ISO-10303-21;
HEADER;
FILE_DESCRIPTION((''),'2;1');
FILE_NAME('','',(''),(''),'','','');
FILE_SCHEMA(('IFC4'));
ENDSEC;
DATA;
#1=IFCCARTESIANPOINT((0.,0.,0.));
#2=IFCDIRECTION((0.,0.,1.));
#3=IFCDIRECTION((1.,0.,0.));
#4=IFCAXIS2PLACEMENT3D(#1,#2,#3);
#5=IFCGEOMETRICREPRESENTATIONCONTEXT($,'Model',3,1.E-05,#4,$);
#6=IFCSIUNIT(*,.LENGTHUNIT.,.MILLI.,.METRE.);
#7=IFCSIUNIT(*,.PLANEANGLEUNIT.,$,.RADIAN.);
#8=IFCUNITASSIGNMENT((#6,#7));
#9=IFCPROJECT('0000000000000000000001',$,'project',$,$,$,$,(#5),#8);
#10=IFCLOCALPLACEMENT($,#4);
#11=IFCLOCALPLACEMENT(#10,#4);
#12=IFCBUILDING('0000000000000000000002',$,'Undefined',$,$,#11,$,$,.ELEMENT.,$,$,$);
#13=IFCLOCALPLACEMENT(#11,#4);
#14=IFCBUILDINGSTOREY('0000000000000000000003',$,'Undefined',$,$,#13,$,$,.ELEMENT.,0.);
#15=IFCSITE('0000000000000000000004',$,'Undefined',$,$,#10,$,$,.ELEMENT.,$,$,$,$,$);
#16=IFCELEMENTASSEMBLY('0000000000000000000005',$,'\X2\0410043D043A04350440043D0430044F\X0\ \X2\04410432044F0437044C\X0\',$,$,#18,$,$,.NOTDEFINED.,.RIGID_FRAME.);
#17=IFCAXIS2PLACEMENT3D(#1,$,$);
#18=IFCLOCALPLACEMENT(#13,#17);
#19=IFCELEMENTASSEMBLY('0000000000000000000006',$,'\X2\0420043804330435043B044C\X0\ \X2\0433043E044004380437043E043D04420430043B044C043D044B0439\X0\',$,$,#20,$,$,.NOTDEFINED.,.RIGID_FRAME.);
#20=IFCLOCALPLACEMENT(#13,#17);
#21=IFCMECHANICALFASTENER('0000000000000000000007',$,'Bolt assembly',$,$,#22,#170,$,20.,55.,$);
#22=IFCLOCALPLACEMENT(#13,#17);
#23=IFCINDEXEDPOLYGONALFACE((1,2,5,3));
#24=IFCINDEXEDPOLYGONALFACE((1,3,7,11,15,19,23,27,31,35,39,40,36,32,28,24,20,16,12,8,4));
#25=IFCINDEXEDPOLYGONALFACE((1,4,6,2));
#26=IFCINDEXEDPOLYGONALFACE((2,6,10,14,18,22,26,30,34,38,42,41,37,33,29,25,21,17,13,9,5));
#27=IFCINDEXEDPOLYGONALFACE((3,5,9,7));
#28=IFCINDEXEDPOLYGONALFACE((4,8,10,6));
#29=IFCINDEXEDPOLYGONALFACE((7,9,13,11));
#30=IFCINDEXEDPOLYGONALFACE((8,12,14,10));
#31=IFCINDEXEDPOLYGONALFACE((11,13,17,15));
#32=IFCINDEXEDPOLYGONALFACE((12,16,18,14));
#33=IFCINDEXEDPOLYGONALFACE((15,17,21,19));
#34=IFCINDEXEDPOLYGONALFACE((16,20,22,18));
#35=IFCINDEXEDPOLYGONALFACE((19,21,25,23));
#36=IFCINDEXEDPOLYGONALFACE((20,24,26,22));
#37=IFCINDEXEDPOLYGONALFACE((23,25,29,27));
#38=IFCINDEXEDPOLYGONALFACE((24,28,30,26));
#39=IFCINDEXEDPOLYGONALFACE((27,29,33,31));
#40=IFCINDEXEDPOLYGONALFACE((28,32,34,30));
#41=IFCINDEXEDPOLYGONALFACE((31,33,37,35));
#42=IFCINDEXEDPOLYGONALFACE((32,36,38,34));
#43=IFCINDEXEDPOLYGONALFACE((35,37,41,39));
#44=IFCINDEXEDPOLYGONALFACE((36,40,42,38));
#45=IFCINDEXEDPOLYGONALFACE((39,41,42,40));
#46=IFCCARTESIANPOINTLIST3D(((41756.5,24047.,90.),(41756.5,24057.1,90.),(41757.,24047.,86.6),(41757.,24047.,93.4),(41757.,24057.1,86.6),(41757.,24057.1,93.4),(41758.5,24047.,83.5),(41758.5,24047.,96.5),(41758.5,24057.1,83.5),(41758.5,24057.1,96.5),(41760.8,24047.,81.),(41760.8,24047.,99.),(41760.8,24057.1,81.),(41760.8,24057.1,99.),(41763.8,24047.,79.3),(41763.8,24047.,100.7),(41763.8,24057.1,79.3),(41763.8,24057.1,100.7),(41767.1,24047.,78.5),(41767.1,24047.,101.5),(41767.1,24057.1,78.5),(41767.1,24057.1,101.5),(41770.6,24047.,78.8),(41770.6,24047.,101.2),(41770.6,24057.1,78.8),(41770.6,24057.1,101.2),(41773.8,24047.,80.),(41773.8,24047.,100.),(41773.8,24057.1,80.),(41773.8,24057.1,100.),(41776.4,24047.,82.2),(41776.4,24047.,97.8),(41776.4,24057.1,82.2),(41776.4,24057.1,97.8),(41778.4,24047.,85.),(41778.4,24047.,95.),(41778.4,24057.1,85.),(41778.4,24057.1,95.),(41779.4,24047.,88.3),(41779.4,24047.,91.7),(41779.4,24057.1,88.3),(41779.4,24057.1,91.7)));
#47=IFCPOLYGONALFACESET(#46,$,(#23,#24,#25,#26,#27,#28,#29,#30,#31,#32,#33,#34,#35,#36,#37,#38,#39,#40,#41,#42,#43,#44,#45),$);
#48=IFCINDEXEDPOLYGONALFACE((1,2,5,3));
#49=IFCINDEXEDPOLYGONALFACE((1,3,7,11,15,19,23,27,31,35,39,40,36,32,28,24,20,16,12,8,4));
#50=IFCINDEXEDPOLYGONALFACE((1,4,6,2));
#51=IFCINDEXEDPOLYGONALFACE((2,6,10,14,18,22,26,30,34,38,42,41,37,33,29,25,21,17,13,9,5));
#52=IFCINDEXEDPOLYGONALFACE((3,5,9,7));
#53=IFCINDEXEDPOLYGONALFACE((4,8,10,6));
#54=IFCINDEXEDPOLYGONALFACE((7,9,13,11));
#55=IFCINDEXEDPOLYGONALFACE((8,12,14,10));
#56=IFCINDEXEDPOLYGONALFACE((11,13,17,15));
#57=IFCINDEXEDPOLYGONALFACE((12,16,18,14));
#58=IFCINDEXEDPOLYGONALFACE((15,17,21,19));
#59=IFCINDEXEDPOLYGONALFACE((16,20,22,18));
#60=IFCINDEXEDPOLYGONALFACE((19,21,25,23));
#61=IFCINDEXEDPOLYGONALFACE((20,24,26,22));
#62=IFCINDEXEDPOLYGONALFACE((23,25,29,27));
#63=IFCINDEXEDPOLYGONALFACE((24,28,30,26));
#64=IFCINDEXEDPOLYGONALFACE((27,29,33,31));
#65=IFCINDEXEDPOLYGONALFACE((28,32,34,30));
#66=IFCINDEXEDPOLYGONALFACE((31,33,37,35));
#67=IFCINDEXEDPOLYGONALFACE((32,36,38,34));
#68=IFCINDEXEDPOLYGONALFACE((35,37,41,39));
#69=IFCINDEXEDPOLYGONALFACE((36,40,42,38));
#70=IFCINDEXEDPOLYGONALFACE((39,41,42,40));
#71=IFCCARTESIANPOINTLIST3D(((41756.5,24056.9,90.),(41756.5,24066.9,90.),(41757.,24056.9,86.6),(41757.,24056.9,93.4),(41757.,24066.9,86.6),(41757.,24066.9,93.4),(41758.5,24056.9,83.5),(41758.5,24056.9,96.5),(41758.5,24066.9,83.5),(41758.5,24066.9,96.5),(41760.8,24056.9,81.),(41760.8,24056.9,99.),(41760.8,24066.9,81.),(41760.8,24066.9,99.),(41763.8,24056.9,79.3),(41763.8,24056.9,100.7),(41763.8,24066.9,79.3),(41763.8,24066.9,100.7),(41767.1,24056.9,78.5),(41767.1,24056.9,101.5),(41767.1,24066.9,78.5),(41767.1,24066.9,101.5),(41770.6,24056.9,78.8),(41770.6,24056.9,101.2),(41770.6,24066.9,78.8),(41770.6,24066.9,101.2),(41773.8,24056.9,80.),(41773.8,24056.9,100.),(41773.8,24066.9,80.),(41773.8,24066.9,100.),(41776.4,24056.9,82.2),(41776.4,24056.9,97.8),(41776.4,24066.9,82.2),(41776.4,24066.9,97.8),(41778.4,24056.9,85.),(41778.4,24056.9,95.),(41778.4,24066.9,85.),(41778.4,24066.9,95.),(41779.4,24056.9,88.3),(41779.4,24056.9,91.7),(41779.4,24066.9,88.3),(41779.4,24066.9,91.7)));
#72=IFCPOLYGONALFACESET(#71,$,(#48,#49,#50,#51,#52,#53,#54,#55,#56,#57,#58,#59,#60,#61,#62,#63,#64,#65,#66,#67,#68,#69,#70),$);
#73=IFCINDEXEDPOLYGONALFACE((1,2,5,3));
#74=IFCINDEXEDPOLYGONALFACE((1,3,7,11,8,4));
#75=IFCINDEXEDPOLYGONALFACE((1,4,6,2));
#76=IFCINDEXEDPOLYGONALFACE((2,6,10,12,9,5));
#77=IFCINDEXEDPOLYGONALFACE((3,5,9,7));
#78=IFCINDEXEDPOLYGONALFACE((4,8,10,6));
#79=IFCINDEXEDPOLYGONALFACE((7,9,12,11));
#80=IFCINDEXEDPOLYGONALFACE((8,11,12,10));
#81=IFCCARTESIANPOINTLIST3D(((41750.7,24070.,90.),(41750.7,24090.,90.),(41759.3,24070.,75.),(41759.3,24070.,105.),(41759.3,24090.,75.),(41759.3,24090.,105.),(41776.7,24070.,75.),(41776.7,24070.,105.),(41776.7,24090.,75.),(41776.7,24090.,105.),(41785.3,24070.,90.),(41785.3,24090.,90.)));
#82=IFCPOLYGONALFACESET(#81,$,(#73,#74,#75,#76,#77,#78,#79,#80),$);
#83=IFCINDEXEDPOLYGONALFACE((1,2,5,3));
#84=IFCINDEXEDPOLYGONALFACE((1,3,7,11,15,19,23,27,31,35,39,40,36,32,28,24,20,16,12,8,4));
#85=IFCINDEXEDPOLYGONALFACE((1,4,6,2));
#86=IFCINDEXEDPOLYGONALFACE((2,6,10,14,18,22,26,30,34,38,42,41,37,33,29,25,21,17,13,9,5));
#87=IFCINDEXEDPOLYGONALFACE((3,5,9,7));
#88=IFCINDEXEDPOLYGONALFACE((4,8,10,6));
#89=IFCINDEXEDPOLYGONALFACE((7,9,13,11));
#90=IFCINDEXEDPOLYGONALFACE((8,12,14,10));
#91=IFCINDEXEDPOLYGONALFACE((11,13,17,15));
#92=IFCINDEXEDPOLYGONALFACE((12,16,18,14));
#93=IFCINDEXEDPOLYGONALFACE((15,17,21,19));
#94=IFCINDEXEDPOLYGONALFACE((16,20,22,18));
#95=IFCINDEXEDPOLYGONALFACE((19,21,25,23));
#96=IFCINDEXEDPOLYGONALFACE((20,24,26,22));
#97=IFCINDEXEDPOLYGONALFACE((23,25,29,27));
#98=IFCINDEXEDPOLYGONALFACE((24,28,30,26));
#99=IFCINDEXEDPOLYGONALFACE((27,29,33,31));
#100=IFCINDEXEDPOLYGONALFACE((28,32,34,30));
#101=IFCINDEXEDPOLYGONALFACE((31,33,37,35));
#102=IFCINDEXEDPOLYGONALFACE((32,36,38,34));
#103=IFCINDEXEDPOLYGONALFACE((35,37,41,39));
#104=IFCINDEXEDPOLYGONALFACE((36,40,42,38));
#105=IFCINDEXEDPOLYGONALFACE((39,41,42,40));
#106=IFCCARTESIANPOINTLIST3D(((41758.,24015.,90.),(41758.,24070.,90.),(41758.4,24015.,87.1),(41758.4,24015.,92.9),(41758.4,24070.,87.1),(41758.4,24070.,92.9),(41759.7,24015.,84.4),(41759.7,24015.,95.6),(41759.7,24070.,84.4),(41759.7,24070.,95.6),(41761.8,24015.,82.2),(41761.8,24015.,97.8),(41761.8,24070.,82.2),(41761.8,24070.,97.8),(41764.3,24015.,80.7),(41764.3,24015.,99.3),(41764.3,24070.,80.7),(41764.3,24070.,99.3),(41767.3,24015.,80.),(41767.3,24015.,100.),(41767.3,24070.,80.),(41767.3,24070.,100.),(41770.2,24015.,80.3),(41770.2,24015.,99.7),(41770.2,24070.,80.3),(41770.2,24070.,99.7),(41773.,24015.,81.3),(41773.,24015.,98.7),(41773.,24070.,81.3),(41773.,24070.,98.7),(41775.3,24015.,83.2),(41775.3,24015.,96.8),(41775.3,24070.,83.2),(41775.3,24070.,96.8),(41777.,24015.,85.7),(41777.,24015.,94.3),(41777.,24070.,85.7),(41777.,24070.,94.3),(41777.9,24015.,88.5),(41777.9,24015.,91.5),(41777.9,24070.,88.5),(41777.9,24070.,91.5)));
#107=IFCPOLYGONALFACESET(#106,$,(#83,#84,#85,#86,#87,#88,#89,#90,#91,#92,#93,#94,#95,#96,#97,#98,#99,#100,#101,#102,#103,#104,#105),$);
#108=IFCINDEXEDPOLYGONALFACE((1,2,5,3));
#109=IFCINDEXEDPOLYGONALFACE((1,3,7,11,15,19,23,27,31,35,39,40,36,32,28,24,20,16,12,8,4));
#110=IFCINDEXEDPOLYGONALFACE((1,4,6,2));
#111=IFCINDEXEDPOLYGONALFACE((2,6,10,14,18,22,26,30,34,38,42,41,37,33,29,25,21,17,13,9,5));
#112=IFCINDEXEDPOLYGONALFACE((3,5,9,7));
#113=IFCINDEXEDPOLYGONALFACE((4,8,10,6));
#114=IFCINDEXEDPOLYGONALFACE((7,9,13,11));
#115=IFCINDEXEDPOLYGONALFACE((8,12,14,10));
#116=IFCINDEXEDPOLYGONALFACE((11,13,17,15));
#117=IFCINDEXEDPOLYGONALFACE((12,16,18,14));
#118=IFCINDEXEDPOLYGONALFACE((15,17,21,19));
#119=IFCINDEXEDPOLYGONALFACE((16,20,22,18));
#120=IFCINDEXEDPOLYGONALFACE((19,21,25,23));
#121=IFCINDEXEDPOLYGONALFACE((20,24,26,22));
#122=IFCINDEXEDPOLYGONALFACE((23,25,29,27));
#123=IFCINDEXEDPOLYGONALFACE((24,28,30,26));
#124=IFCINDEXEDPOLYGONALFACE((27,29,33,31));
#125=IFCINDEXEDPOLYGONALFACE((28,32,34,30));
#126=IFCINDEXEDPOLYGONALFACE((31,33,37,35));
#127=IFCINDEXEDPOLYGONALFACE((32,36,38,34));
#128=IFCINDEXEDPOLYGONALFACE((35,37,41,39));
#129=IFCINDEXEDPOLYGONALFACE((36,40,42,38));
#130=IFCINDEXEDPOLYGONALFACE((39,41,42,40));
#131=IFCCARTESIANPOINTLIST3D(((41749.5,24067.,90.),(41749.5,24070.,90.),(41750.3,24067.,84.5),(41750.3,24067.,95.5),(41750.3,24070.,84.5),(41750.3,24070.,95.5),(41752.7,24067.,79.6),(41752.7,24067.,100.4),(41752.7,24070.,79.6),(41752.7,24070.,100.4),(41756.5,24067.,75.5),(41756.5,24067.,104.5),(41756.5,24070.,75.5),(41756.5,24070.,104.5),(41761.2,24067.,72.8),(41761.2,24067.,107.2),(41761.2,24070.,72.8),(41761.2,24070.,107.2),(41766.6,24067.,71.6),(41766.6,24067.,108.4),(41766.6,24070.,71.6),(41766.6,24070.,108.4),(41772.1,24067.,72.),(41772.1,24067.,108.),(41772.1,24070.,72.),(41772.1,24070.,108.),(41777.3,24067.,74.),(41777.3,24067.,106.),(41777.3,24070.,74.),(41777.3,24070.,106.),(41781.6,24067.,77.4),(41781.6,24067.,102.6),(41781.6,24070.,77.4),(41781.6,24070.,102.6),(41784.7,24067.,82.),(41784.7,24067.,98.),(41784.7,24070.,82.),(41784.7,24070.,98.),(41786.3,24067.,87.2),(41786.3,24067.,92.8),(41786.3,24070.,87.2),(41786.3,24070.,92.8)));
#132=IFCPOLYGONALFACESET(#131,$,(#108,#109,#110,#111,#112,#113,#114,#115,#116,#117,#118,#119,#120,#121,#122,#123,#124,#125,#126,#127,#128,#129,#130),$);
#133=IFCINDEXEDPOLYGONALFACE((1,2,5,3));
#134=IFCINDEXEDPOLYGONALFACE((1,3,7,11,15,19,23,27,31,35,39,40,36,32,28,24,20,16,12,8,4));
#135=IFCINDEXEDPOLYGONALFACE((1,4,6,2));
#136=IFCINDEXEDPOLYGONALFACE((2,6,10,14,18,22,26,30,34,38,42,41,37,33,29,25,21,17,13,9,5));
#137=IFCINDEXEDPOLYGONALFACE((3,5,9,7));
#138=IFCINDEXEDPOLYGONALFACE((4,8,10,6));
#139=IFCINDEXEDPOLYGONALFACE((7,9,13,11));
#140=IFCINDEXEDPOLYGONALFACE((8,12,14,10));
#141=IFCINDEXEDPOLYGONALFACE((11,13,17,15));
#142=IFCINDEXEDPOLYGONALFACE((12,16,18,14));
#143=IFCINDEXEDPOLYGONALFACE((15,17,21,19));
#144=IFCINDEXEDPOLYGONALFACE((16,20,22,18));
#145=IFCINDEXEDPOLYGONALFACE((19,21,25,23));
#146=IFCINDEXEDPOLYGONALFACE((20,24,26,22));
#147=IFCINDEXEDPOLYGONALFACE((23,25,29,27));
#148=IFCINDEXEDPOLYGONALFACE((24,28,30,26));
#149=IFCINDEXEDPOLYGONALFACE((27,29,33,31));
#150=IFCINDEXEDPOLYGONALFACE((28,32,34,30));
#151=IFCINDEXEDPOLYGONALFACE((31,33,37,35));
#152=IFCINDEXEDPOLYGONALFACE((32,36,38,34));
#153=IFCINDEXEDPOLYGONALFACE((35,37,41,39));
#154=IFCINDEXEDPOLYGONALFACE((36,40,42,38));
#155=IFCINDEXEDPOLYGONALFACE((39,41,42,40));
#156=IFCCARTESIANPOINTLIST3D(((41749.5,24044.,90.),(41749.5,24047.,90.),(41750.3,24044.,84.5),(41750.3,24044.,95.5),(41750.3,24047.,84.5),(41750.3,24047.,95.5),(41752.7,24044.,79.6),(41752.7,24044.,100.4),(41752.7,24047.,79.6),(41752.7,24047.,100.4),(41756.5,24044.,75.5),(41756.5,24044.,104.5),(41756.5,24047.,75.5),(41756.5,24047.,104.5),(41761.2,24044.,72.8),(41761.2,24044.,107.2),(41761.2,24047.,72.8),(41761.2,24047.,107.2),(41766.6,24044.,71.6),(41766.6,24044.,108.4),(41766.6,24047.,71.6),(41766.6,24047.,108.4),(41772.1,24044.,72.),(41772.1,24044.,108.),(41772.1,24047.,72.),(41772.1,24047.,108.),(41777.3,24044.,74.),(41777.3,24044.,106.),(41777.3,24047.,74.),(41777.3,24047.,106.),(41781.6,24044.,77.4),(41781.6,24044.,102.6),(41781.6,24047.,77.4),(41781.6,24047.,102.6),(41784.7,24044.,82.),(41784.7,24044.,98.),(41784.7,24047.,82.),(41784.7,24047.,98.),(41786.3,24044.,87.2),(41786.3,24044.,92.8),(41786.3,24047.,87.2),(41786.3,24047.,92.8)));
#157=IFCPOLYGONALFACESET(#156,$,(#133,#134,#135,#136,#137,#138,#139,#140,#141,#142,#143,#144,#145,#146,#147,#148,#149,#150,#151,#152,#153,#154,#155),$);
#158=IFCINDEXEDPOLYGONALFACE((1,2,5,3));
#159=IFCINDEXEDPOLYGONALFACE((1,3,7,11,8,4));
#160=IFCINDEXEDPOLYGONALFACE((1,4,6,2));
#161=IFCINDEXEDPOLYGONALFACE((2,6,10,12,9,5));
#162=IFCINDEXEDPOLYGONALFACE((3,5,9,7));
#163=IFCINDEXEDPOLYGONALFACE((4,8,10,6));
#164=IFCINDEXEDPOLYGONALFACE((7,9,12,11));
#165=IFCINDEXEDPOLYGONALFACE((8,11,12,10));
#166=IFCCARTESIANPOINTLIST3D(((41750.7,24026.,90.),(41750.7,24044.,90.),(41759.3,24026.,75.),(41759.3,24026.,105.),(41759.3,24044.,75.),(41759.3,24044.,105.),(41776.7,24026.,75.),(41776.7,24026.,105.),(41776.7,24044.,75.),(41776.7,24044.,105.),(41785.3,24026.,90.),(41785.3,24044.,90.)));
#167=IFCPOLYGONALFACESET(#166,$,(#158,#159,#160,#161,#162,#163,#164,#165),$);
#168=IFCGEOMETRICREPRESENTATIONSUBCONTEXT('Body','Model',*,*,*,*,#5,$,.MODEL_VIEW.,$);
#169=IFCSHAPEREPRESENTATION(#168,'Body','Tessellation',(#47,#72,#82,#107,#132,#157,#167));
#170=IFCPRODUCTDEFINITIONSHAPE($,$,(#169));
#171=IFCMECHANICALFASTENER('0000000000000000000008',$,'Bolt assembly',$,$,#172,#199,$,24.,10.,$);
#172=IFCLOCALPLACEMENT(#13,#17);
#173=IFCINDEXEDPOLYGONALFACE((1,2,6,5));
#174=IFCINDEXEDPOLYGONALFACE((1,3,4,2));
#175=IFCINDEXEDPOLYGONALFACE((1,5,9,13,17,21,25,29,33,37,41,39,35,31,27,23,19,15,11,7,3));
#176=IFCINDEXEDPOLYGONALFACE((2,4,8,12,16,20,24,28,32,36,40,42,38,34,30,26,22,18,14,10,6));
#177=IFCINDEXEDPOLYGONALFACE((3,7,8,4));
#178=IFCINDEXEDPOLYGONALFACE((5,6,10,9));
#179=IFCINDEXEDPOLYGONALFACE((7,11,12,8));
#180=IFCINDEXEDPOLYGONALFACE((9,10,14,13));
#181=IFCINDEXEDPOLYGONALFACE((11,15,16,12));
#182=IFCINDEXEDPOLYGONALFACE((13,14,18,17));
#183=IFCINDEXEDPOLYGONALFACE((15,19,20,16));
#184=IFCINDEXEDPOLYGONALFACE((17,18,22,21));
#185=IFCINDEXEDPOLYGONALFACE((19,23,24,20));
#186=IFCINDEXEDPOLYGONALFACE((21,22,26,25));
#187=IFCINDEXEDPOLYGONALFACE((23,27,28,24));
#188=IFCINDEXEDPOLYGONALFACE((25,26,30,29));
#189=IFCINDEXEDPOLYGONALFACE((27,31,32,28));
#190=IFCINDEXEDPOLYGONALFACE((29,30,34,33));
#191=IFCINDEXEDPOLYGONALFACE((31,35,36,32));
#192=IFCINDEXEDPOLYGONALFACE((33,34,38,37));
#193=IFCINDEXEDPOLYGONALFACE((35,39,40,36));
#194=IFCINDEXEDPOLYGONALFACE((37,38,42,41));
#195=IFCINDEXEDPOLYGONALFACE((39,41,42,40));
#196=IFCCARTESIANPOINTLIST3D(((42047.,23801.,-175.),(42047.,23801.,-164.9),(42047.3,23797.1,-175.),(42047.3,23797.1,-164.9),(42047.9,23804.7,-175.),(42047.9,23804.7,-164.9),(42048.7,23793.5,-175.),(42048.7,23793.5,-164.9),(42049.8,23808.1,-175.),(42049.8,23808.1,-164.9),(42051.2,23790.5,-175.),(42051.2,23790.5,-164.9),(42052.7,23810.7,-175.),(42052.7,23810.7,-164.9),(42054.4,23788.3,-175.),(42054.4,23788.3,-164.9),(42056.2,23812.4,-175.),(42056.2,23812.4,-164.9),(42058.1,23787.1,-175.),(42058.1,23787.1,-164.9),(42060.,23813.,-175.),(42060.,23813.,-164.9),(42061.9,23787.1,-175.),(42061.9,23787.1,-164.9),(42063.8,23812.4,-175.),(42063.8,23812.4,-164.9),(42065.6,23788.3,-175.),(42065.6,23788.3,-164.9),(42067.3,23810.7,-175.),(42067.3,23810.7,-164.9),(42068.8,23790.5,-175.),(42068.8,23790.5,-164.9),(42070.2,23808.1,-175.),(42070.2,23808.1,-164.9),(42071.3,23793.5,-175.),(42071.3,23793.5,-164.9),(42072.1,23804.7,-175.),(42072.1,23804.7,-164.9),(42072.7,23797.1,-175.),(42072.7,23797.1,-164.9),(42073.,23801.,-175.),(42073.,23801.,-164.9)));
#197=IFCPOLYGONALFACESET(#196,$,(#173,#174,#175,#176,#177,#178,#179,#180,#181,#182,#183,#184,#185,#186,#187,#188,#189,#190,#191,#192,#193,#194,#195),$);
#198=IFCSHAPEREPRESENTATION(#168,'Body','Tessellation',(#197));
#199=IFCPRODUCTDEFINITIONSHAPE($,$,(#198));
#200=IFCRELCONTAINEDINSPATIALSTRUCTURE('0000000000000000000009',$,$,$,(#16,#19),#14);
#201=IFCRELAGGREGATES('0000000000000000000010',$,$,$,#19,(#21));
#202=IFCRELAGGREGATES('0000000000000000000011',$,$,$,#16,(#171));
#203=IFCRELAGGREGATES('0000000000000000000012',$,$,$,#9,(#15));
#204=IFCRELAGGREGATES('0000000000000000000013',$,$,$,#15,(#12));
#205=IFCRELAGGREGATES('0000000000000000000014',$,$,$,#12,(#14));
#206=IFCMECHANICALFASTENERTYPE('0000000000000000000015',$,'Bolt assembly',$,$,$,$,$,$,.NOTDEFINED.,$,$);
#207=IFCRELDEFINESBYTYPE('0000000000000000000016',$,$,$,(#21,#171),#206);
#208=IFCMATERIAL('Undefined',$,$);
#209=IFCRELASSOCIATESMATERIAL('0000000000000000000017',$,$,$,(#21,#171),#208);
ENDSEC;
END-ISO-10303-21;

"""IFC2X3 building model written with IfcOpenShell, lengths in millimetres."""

from ifc_helpers import new_model, si_unit, frame, origin_with_axes, origin_2d_with_axis, place, context, subcontext, project, spatial, polyline, circle, outline, extrude, source, transform, mapped, material, type_object, element, aggregate, save


model = new_model("IFC2X3")

# Units and contexts
model_context = context("Model", 3, precision=1e-05, world=origin_with_axes())
body_context = subcontext(model_context, "Body", "Model", "MODEL_VIEW")
ifc_project = project(units=[si_unit("LENGTHUNIT", "METRE", prefix="MILLI"), si_unit("PLANEANGLEUNIT", "RADIAN")], contexts=[model_context])

# Site, building, storey
site_placement = place(None, origin_with_axes())
site = spatial("IfcSite", under=ifc_project, at=site_placement, Name="Undefined", CompositionType="ELEMENT")
building_placement = place(site_placement, origin_with_axes())
building = spatial("IfcBuilding", under=site, at=building_placement, Name="Undefined", CompositionType="ELEMENT")
storey_placement = place(building_placement, origin_with_axes())
storey = spatial("IfcBuildingStorey", under=building, at=storey_placement, Name="Undefined", CompositionType="ELEMENT", Elevation=0.0)

# Element assembly
assembly_1_placement = place(storey_placement, origin_with_axes())
assembly_1 = element("IfcElementAssembly", 1, at=assembly_1_placement, inside=storey, Name="Анкерная связь", AssemblyPlace="NOTDEFINED", PredefinedType="RIGID_FRAME")

# Shared definitions
ifc_material_1 = material(Name="Undefined")
mechanical_fastener_type = type_object("IfcMechanicalFastenerType", Name="Bolt assembly")

# Element assembly, mechanical fastener
assembly_2_placement = place(storey_placement, origin_with_axes())
assembly_2 = element("IfcElementAssembly", 2, at=assembly_2_placement, inside=storey, Name="Ригель горизонтальный", AssemblyPlace="NOTDEFINED", PredefinedType="RIGID_FRAME")
shared_shape_1 = source(origin_with_axes(), body_context, "Body", "SweptSolid", [
    extrude(circle(Radius=11.5, at=origin_2d_with_axis()), frame((0.0, -0.1, 0.0), z_axis=(0.0, 1.0, 0.0), x_axis=(1.0, 0.0, 0.0)), (0.0, 0.0, 1.0), 10.1),
    extrude(circle(Radius=11.5, at=origin_2d_with_axis()), frame((0.0, -9.9, 0.0), z_axis=(0.0, 1.0, 0.0), x_axis=(1.0, 0.0, 0.0)), (0.0, 0.0, 1.0), 10.0),
    extrude(outline(polyline([(17.3, 0.0), (8.7, 15.0), (-8.7, 15.0), (-17.3, 0.0), (-8.7, -15.0), (8.7, -15.0), (17.3, 0.0)])), frame((0.0, -33.0, 0.0), z_axis=(0.0, 1.0, 0.0), x_axis=(1.0, 0.0, 0.0)), (0.0, 0.0, 1.0), 20.0),
    extrude(circle(Radius=10.0, at=origin_2d_with_axis()), frame((0.0, -13.0, 0.0), z_axis=(0.0, 1.0, 0.0), x_axis=(1.0, 0.0, 0.0)), (0.0, 0.0, 1.0), 55.0),
    extrude(circle(Radius=18.5, at=origin_2d_with_axis()), frame((0.0, -13.0, 0.0), z_axis=(0.0, 1.0, 0.0), x_axis=(1.0, 0.0, 0.0)), (0.0, 0.0, 1.0), 3.0),
    extrude(circle(Radius=18.5, at=origin_2d_with_axis()), frame((0.0, 10.0, 0.0), z_axis=(0.0, 1.0, 0.0), x_axis=(1.0, 0.0, 0.0)), (0.0, 0.0, 1.0), 3.0),
    extrude(outline(polyline([(17.3, 0.0), (8.7, 15.0), (-8.7, 15.0), (-17.3, 0.0), (-8.7, -15.0), (8.7, -15.0), (17.3, 0.0)])), frame((0.0, 13.0, 0.0), z_axis=(0.0, 1.0, 0.0), x_axis=(1.0, 0.0, 0.0)), (0.0, 0.0, 1.0), 18.0),
])
mechanical_fastener_1_placement = place(assembly_2_placement, frame((41768.0, 24057.0, 90.0), z_axis=(0.0, 0.0, 1.0), x_axis=(-1.0, 0.0, 0.0)))
mechanical_fastener_1 = element("IfcMechanicalFastener", 3, at=mechanical_fastener_1_placement, type_object=mechanical_fastener_type, material=ifc_material_1, Name="Bolt assembly", NominalDiameter=20.0, NominalLength=55.0, context=body_context, shape_type="MappedRepresentation", body=[
    mapped(shared_shape_1, transform((0.0, 0.0, 0.0))),
])
aggregate(assembly_2, [mechanical_fastener_1])

# Mechanical fastener
shared_shape_2 = source(origin_with_axes(), body_context, "Body", "SweptSolid", [
    extrude(circle(Radius=13.0, at=origin_2d_with_axis()), frame((0.0, 0.0, 0.0), z_axis=(0.0, 1.0, 0.0), x_axis=(1.0, 0.0, 0.0)), (0.0, 0.0, 1.0), 10.1),
])
mechanical_fastener_2_placement = place(assembly_1_placement, frame((42060.0, 23800.0, -175.0), z_axis=(1.0, 0.0, 0.0), x_axis=(0.0, 1.0, 0.0)))
mechanical_fastener_2 = element("IfcMechanicalFastener", 4, at=mechanical_fastener_2_placement, type_object=mechanical_fastener_type, material=ifc_material_1, Name="Bolt assembly", NominalDiameter=24.0, NominalLength=10.0, context=body_context, shape_type="MappedRepresentation", body=[
    mapped(shared_shape_2, transform((0.0, 0.0, 0.0))),
])
aggregate(assembly_1, [mechanical_fastener_2])

save(model, "model.ifc")
